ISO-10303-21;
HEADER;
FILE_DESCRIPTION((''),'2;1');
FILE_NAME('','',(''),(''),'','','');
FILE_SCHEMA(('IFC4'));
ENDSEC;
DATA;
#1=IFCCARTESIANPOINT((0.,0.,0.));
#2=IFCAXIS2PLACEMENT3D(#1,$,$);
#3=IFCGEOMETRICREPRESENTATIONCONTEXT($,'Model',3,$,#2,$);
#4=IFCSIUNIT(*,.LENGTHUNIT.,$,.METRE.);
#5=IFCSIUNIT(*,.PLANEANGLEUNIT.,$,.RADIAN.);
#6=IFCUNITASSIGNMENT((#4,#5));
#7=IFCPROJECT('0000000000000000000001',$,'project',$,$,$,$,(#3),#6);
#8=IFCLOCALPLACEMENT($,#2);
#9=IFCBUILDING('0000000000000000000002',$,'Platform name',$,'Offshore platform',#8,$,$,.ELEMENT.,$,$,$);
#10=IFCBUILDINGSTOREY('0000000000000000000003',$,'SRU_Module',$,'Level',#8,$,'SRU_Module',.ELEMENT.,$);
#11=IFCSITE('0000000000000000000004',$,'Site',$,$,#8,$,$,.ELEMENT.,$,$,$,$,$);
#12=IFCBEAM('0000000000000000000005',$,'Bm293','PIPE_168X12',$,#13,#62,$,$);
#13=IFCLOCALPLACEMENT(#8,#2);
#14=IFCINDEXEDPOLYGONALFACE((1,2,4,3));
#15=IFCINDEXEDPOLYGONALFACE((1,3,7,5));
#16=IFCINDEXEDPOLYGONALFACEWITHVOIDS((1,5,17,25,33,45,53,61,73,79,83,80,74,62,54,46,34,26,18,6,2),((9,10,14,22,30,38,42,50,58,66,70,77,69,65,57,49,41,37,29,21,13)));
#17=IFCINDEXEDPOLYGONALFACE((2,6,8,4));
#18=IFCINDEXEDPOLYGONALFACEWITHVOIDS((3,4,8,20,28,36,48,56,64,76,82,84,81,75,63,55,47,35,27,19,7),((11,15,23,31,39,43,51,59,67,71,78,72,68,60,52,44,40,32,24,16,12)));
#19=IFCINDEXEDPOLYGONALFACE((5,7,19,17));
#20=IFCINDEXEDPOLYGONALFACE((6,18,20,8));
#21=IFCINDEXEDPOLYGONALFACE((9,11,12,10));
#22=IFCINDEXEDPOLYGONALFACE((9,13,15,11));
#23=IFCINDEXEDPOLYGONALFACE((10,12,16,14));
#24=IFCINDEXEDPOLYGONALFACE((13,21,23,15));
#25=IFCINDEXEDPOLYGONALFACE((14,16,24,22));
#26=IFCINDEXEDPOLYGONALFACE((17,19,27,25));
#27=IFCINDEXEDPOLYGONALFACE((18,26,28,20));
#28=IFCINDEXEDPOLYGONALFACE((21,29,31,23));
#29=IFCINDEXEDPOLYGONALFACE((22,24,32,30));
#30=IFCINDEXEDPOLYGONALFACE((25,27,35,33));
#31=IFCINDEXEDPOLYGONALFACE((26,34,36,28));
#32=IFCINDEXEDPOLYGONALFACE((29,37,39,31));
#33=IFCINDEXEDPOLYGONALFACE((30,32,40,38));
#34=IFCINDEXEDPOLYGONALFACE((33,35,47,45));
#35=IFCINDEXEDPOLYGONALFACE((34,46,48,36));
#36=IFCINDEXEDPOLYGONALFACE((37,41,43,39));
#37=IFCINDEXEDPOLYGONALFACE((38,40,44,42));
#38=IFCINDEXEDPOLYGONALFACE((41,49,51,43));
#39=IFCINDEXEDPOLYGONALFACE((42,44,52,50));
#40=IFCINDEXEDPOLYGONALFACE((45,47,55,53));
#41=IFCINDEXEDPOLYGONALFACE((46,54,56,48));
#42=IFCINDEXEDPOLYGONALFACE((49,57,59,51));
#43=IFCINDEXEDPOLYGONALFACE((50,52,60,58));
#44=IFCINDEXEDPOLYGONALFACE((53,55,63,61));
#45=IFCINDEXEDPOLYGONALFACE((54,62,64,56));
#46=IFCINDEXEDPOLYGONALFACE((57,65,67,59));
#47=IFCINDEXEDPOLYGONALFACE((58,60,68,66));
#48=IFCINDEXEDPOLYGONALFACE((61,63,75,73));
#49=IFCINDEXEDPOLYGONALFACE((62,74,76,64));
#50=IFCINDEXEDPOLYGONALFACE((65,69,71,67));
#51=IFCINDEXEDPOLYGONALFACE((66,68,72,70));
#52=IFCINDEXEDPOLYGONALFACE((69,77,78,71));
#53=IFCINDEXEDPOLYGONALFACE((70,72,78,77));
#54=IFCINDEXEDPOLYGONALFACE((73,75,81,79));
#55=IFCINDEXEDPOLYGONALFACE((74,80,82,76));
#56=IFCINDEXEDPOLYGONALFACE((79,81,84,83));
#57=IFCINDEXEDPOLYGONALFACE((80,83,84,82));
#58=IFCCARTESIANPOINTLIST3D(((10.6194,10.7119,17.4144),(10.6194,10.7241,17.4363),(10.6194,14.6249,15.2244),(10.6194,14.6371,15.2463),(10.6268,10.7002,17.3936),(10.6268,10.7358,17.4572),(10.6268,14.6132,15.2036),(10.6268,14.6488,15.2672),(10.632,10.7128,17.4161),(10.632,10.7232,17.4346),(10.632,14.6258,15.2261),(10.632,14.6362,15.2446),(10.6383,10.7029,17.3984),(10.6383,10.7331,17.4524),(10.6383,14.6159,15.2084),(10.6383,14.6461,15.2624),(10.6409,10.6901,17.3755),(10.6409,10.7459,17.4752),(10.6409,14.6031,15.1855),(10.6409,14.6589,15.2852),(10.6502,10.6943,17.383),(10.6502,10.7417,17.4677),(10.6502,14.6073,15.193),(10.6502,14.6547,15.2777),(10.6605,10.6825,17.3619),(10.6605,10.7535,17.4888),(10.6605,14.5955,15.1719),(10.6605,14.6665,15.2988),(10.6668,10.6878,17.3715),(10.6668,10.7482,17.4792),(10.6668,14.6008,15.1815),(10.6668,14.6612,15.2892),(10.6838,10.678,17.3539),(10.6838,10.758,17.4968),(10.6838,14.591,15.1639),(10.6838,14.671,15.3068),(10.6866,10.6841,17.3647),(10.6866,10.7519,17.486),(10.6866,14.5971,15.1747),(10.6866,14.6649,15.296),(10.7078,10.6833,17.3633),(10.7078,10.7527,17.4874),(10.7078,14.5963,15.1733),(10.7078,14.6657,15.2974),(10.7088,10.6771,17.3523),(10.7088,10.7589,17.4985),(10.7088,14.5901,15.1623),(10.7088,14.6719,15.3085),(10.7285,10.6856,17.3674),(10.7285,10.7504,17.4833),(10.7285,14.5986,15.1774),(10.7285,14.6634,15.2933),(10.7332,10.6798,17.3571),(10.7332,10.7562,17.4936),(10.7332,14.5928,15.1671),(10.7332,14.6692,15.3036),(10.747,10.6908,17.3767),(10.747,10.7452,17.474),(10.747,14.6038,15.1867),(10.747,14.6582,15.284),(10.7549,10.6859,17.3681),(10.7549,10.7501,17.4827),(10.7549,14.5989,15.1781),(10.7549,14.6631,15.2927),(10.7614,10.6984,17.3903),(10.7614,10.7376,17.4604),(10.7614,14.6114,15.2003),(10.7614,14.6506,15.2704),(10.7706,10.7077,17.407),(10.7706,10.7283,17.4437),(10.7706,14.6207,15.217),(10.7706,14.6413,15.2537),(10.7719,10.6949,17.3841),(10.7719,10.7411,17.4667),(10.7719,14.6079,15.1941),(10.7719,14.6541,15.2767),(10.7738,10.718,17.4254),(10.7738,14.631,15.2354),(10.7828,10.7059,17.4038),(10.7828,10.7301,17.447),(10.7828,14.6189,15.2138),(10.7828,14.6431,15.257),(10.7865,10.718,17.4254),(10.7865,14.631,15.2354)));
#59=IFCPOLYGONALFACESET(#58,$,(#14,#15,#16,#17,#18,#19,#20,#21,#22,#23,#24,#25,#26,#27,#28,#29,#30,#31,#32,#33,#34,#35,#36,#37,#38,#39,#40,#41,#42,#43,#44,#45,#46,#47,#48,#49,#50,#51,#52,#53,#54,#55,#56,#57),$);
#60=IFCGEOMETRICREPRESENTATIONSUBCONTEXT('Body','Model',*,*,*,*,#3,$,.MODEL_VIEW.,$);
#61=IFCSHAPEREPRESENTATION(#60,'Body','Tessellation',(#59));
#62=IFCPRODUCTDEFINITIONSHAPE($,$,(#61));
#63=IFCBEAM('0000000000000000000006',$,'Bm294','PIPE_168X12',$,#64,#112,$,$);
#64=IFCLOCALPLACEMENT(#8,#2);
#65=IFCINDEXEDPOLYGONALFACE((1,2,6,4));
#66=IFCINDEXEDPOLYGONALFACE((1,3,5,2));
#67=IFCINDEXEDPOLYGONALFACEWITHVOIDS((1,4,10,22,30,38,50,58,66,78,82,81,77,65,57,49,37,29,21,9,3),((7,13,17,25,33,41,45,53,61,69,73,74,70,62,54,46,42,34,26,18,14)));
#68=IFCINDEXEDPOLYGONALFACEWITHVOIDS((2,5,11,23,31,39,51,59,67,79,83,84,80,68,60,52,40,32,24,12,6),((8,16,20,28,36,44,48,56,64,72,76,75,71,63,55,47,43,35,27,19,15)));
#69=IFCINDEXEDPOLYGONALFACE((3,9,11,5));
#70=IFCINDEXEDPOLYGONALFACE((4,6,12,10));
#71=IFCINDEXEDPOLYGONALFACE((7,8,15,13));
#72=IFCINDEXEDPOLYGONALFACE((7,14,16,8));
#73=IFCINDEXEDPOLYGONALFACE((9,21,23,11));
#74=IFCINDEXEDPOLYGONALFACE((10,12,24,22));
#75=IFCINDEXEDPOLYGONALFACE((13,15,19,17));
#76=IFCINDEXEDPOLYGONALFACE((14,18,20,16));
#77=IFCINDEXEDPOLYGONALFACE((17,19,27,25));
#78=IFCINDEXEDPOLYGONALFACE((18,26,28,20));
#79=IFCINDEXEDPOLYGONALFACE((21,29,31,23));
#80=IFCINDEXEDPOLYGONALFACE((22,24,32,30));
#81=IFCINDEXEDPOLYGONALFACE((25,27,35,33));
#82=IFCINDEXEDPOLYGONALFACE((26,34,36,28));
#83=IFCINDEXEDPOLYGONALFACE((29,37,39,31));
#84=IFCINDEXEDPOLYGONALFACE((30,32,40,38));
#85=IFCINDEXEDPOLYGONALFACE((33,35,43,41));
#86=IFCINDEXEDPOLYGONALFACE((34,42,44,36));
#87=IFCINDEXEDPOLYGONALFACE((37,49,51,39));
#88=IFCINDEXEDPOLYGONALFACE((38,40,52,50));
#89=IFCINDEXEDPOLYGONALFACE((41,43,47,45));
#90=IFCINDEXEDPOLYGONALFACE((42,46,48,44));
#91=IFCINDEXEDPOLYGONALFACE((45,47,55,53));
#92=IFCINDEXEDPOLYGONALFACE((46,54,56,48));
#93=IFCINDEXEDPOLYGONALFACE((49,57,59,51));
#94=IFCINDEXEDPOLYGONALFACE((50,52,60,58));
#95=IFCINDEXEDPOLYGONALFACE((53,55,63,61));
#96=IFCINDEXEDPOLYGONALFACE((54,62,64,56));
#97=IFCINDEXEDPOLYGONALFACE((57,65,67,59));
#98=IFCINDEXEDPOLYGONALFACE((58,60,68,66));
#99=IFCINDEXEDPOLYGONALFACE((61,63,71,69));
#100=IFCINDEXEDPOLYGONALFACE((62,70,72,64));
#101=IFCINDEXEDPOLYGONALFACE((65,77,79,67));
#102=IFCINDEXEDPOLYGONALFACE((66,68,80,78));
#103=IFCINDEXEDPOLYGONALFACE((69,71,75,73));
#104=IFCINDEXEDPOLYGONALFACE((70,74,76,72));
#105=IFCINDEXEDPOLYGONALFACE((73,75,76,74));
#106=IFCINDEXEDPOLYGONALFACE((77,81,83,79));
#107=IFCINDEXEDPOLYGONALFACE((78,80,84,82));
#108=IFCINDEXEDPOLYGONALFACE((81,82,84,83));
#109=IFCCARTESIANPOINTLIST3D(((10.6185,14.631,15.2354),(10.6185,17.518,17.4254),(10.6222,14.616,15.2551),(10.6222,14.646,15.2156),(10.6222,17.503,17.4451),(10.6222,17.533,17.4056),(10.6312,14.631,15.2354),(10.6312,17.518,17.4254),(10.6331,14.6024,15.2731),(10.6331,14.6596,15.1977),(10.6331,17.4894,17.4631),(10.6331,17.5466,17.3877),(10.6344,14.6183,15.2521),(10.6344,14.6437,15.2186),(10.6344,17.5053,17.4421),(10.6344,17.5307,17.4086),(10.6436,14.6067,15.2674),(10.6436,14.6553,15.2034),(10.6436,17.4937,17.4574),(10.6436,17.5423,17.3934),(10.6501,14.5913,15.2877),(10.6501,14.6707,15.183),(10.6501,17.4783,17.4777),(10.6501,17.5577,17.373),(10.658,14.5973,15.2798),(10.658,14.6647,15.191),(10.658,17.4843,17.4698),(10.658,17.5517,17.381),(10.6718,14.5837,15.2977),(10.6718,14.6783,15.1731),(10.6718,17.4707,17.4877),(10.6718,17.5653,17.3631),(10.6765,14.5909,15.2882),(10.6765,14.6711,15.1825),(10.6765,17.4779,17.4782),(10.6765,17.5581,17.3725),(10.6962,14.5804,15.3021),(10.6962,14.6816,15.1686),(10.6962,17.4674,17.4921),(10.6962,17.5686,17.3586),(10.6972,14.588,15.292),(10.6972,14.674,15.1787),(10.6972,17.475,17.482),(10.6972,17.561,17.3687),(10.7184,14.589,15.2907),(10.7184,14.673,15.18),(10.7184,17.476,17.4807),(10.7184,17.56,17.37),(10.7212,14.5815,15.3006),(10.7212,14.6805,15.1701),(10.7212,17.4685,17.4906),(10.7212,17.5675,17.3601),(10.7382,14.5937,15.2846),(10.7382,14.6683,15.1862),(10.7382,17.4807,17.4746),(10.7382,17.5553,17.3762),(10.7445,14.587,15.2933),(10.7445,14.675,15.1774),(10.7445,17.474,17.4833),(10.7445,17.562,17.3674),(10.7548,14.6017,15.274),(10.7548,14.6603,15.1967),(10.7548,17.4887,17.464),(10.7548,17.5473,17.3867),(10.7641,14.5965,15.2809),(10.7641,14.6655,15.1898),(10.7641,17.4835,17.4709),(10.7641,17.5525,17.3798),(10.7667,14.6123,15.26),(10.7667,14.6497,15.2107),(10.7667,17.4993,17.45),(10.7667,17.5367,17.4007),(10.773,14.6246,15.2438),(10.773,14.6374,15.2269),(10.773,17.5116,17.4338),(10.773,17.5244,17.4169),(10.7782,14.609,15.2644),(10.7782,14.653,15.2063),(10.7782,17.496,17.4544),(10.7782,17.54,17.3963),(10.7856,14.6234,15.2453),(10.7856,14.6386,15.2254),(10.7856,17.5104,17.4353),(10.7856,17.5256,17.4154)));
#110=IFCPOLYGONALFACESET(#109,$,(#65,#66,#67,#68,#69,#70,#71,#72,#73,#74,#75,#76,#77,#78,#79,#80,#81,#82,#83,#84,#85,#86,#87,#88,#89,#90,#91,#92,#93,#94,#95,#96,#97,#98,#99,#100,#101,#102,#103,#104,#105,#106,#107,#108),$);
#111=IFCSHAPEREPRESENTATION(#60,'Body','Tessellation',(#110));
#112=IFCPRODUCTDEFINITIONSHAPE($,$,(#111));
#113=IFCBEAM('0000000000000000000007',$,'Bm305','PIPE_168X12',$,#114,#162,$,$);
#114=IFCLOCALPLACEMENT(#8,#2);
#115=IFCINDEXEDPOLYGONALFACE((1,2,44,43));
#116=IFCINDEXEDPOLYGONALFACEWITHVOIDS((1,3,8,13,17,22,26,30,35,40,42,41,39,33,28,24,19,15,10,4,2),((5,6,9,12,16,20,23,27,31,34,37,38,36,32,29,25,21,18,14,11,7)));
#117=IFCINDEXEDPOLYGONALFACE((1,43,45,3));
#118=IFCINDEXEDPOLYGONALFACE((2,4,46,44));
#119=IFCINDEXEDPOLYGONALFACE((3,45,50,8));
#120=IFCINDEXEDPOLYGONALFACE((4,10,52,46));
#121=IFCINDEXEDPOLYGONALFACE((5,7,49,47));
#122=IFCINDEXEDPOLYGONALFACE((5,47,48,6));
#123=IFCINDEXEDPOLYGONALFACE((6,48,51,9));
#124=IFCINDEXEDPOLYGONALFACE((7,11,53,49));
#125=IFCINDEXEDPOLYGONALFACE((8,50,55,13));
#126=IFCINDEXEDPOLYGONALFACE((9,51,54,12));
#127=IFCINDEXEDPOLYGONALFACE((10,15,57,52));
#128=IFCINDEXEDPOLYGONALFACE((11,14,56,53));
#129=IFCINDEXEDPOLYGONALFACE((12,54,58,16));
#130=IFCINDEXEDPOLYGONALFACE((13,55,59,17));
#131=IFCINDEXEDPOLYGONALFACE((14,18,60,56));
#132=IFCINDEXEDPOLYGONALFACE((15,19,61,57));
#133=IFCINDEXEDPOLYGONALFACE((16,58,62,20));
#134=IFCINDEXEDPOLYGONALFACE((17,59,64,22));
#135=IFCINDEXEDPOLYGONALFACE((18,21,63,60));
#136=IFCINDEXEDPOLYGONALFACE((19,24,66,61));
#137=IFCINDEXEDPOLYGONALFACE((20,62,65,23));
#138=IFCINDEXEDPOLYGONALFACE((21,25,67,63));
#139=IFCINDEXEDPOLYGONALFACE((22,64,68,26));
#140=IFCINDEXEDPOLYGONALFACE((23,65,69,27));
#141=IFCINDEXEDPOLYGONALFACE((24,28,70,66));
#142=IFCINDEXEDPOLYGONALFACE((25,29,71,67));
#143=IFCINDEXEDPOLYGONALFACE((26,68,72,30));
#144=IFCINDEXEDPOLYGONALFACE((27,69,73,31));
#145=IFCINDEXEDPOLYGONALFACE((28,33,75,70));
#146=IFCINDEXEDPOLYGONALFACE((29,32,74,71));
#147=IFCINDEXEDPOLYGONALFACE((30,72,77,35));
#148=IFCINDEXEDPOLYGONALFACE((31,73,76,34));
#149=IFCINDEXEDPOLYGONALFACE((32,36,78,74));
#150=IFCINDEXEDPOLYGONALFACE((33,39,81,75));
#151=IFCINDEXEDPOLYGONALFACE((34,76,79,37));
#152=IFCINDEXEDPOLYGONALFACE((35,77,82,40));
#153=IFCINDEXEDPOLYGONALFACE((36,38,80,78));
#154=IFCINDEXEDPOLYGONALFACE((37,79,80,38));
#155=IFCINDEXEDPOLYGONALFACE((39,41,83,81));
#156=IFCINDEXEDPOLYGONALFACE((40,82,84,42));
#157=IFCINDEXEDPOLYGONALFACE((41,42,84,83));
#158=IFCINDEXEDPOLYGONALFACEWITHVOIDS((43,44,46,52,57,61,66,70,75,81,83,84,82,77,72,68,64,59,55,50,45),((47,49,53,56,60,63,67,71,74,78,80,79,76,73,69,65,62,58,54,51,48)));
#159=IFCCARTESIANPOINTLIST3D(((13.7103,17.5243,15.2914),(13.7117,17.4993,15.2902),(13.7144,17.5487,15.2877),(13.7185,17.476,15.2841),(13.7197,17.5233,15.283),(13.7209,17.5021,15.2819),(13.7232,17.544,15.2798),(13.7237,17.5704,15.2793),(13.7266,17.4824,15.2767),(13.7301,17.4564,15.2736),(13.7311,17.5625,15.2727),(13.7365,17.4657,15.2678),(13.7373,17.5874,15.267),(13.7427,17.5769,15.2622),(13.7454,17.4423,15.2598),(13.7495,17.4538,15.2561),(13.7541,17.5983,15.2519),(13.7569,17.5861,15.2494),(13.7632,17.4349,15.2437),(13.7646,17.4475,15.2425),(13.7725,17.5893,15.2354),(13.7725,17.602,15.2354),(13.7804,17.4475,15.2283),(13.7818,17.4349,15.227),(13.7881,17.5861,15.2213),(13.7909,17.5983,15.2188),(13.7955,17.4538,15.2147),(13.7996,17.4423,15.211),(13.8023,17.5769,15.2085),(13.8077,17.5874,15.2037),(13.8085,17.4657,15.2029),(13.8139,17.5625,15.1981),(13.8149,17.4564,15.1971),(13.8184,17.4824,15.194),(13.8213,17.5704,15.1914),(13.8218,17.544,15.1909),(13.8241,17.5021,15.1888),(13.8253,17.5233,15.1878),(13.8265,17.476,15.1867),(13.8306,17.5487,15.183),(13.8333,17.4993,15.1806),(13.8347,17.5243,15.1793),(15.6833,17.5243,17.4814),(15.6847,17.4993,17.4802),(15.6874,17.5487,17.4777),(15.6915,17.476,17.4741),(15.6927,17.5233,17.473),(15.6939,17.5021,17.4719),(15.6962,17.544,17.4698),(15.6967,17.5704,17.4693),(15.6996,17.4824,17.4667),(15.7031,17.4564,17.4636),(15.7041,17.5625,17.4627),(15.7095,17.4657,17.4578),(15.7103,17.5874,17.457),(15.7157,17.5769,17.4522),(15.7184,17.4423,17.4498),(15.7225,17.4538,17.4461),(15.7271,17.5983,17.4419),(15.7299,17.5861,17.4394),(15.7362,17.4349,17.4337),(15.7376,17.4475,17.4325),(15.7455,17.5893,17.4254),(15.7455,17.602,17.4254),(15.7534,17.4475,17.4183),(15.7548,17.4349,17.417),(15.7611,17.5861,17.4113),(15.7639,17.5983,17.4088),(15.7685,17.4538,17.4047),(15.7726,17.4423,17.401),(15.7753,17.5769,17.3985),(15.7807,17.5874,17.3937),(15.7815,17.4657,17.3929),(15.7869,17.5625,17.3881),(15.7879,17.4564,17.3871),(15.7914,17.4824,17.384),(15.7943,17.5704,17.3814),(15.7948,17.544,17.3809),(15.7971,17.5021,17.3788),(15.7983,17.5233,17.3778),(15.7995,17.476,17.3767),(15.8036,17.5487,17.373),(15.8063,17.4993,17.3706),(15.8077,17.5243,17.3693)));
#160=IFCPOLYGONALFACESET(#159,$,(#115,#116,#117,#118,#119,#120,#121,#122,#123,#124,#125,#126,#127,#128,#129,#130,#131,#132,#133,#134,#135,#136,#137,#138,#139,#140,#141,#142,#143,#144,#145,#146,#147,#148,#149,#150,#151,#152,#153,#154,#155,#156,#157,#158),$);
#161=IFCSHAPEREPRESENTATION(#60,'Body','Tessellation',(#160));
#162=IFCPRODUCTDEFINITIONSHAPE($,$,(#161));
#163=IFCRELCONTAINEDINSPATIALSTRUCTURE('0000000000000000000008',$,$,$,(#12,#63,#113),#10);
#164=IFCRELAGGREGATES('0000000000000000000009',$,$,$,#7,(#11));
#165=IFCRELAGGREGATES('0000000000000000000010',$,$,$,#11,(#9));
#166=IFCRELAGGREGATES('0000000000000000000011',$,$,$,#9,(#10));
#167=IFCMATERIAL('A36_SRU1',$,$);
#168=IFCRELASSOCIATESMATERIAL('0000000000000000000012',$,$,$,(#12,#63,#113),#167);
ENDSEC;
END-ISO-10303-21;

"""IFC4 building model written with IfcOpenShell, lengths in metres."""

from ifc_helpers import new_model, si_unit, frame, origin, origin_2d, place, context, subcontext, project, spatial, hollow_circle, extrude, source, transform, mapped, material, element, save


model = new_model("IFC4")

# Units and contexts
model_context = context("Model", 3, world=origin())
body_context = subcontext(model_context, "Body", "Model", "MODEL_VIEW")
ifc_project = project(units=[si_unit("LENGTHUNIT", "METRE"), si_unit("PLANEANGLEUNIT", "RADIAN")], contexts=[model_context])

# Site, building, storey
placement_1 = place(None, origin())
site = spatial("IfcSite", under=ifc_project, at=placement_1, Name="Site", CompositionType="ELEMENT")
building = spatial("IfcBuilding", under=site, at=placement_1, Name="Platform name", ObjectType="Offshore platform", CompositionType="ELEMENT")
storey = spatial("IfcBuildingStorey", under=building, at=placement_1, Name="SRU_Module", ObjectType="Level", LongName="SRU_Module", CompositionType="ELEMENT")

# Beams
ifc_material_1 = material(Name="A36_SRU1")
shared_shape_1 = source(origin(), body_context, "Body", "SweptSolid", [
    extrude(hollow_circle(Radius=0.084, WallThickness=0.0127, at=origin_2d()), frame((0.0, 0.0, 0.0), z_axis=(0.0, -0.872628, 0.488386), x_axis=(1.0, 0.0, 0.0)), (0.0, 0.0, 1.0), 4.4842),
])
placement_2 = place(None, origin())
placement_3 = place(placement_2, origin())
placement_4 = place(placement_3, origin())
beam_1_placement = place(placement_4, frame((10.7025, 14.631, 15.2354)))
element("IfcBeam", 1, at=beam_1_placement, inside=storey, material=ifc_material_1, Name="Bm293", Description="PIPE_168X12", context=body_context, shape_type="MappedRepresentation", body=[
    mapped(shared_shape_1, transform((0.0, 0.0, 0.0), scale=1.0)),
])
shared_shape_2 = source(origin(), body_context, "Body", "SweptSolid", [
    extrude(hollow_circle(Radius=0.084, WallThickness=0.0127, at=origin_2d()), frame((0.0, 0.0, 0.0), z_axis=(0.0, 0.79671, 0.604362), x_axis=(-1.0, 0.0, 0.0)), (0.0, 0.0, 1.0), 3.6237),
])
placement_5 = place(None, origin())
placement_6 = place(placement_5, origin())
placement_7 = place(placement_6, origin())
beam_2_placement = place(placement_7, frame((10.7025, 14.631, 15.2354)))
element("IfcBeam", 2, at=beam_2_placement, inside=storey, material=ifc_material_1, Name="Bm294", Description="PIPE_168X12", context=body_context, shape_type="MappedRepresentation", body=[
    mapped(shared_shape_2, transform((0.0, 0.0, 0.0), scale=1.0)),
])
shared_shape_3 = source(origin(), body_context, "Body", "SweptSolid", [
    extrude(hollow_circle(Radius=0.084, WallThickness=0.0127, at=origin_2d()), frame((0.0, 0.0, 0.0), z_axis=(0.66934, 0.0, 0.742957), x_axis=(0.0, 1.0, 0.0)), (0.0, 0.0, 1.0), 2.9477),
])
placement_8 = place(None, origin())
placement_9 = place(placement_8, origin())
placement_10 = place(placement_9, origin())
beam_3_placement = place(placement_10, frame((13.7725, 17.518, 15.2354)))
element("IfcBeam", 3, at=beam_3_placement, inside=storey, material=ifc_material_1, Name="Bm305", Description="PIPE_168X12", context=body_context, shape_type="MappedRepresentation", body=[
    mapped(shared_shape_3, transform((0.0, 0.0, 0.0), scale=1.0)),
])

save(model, "model.ifc")
